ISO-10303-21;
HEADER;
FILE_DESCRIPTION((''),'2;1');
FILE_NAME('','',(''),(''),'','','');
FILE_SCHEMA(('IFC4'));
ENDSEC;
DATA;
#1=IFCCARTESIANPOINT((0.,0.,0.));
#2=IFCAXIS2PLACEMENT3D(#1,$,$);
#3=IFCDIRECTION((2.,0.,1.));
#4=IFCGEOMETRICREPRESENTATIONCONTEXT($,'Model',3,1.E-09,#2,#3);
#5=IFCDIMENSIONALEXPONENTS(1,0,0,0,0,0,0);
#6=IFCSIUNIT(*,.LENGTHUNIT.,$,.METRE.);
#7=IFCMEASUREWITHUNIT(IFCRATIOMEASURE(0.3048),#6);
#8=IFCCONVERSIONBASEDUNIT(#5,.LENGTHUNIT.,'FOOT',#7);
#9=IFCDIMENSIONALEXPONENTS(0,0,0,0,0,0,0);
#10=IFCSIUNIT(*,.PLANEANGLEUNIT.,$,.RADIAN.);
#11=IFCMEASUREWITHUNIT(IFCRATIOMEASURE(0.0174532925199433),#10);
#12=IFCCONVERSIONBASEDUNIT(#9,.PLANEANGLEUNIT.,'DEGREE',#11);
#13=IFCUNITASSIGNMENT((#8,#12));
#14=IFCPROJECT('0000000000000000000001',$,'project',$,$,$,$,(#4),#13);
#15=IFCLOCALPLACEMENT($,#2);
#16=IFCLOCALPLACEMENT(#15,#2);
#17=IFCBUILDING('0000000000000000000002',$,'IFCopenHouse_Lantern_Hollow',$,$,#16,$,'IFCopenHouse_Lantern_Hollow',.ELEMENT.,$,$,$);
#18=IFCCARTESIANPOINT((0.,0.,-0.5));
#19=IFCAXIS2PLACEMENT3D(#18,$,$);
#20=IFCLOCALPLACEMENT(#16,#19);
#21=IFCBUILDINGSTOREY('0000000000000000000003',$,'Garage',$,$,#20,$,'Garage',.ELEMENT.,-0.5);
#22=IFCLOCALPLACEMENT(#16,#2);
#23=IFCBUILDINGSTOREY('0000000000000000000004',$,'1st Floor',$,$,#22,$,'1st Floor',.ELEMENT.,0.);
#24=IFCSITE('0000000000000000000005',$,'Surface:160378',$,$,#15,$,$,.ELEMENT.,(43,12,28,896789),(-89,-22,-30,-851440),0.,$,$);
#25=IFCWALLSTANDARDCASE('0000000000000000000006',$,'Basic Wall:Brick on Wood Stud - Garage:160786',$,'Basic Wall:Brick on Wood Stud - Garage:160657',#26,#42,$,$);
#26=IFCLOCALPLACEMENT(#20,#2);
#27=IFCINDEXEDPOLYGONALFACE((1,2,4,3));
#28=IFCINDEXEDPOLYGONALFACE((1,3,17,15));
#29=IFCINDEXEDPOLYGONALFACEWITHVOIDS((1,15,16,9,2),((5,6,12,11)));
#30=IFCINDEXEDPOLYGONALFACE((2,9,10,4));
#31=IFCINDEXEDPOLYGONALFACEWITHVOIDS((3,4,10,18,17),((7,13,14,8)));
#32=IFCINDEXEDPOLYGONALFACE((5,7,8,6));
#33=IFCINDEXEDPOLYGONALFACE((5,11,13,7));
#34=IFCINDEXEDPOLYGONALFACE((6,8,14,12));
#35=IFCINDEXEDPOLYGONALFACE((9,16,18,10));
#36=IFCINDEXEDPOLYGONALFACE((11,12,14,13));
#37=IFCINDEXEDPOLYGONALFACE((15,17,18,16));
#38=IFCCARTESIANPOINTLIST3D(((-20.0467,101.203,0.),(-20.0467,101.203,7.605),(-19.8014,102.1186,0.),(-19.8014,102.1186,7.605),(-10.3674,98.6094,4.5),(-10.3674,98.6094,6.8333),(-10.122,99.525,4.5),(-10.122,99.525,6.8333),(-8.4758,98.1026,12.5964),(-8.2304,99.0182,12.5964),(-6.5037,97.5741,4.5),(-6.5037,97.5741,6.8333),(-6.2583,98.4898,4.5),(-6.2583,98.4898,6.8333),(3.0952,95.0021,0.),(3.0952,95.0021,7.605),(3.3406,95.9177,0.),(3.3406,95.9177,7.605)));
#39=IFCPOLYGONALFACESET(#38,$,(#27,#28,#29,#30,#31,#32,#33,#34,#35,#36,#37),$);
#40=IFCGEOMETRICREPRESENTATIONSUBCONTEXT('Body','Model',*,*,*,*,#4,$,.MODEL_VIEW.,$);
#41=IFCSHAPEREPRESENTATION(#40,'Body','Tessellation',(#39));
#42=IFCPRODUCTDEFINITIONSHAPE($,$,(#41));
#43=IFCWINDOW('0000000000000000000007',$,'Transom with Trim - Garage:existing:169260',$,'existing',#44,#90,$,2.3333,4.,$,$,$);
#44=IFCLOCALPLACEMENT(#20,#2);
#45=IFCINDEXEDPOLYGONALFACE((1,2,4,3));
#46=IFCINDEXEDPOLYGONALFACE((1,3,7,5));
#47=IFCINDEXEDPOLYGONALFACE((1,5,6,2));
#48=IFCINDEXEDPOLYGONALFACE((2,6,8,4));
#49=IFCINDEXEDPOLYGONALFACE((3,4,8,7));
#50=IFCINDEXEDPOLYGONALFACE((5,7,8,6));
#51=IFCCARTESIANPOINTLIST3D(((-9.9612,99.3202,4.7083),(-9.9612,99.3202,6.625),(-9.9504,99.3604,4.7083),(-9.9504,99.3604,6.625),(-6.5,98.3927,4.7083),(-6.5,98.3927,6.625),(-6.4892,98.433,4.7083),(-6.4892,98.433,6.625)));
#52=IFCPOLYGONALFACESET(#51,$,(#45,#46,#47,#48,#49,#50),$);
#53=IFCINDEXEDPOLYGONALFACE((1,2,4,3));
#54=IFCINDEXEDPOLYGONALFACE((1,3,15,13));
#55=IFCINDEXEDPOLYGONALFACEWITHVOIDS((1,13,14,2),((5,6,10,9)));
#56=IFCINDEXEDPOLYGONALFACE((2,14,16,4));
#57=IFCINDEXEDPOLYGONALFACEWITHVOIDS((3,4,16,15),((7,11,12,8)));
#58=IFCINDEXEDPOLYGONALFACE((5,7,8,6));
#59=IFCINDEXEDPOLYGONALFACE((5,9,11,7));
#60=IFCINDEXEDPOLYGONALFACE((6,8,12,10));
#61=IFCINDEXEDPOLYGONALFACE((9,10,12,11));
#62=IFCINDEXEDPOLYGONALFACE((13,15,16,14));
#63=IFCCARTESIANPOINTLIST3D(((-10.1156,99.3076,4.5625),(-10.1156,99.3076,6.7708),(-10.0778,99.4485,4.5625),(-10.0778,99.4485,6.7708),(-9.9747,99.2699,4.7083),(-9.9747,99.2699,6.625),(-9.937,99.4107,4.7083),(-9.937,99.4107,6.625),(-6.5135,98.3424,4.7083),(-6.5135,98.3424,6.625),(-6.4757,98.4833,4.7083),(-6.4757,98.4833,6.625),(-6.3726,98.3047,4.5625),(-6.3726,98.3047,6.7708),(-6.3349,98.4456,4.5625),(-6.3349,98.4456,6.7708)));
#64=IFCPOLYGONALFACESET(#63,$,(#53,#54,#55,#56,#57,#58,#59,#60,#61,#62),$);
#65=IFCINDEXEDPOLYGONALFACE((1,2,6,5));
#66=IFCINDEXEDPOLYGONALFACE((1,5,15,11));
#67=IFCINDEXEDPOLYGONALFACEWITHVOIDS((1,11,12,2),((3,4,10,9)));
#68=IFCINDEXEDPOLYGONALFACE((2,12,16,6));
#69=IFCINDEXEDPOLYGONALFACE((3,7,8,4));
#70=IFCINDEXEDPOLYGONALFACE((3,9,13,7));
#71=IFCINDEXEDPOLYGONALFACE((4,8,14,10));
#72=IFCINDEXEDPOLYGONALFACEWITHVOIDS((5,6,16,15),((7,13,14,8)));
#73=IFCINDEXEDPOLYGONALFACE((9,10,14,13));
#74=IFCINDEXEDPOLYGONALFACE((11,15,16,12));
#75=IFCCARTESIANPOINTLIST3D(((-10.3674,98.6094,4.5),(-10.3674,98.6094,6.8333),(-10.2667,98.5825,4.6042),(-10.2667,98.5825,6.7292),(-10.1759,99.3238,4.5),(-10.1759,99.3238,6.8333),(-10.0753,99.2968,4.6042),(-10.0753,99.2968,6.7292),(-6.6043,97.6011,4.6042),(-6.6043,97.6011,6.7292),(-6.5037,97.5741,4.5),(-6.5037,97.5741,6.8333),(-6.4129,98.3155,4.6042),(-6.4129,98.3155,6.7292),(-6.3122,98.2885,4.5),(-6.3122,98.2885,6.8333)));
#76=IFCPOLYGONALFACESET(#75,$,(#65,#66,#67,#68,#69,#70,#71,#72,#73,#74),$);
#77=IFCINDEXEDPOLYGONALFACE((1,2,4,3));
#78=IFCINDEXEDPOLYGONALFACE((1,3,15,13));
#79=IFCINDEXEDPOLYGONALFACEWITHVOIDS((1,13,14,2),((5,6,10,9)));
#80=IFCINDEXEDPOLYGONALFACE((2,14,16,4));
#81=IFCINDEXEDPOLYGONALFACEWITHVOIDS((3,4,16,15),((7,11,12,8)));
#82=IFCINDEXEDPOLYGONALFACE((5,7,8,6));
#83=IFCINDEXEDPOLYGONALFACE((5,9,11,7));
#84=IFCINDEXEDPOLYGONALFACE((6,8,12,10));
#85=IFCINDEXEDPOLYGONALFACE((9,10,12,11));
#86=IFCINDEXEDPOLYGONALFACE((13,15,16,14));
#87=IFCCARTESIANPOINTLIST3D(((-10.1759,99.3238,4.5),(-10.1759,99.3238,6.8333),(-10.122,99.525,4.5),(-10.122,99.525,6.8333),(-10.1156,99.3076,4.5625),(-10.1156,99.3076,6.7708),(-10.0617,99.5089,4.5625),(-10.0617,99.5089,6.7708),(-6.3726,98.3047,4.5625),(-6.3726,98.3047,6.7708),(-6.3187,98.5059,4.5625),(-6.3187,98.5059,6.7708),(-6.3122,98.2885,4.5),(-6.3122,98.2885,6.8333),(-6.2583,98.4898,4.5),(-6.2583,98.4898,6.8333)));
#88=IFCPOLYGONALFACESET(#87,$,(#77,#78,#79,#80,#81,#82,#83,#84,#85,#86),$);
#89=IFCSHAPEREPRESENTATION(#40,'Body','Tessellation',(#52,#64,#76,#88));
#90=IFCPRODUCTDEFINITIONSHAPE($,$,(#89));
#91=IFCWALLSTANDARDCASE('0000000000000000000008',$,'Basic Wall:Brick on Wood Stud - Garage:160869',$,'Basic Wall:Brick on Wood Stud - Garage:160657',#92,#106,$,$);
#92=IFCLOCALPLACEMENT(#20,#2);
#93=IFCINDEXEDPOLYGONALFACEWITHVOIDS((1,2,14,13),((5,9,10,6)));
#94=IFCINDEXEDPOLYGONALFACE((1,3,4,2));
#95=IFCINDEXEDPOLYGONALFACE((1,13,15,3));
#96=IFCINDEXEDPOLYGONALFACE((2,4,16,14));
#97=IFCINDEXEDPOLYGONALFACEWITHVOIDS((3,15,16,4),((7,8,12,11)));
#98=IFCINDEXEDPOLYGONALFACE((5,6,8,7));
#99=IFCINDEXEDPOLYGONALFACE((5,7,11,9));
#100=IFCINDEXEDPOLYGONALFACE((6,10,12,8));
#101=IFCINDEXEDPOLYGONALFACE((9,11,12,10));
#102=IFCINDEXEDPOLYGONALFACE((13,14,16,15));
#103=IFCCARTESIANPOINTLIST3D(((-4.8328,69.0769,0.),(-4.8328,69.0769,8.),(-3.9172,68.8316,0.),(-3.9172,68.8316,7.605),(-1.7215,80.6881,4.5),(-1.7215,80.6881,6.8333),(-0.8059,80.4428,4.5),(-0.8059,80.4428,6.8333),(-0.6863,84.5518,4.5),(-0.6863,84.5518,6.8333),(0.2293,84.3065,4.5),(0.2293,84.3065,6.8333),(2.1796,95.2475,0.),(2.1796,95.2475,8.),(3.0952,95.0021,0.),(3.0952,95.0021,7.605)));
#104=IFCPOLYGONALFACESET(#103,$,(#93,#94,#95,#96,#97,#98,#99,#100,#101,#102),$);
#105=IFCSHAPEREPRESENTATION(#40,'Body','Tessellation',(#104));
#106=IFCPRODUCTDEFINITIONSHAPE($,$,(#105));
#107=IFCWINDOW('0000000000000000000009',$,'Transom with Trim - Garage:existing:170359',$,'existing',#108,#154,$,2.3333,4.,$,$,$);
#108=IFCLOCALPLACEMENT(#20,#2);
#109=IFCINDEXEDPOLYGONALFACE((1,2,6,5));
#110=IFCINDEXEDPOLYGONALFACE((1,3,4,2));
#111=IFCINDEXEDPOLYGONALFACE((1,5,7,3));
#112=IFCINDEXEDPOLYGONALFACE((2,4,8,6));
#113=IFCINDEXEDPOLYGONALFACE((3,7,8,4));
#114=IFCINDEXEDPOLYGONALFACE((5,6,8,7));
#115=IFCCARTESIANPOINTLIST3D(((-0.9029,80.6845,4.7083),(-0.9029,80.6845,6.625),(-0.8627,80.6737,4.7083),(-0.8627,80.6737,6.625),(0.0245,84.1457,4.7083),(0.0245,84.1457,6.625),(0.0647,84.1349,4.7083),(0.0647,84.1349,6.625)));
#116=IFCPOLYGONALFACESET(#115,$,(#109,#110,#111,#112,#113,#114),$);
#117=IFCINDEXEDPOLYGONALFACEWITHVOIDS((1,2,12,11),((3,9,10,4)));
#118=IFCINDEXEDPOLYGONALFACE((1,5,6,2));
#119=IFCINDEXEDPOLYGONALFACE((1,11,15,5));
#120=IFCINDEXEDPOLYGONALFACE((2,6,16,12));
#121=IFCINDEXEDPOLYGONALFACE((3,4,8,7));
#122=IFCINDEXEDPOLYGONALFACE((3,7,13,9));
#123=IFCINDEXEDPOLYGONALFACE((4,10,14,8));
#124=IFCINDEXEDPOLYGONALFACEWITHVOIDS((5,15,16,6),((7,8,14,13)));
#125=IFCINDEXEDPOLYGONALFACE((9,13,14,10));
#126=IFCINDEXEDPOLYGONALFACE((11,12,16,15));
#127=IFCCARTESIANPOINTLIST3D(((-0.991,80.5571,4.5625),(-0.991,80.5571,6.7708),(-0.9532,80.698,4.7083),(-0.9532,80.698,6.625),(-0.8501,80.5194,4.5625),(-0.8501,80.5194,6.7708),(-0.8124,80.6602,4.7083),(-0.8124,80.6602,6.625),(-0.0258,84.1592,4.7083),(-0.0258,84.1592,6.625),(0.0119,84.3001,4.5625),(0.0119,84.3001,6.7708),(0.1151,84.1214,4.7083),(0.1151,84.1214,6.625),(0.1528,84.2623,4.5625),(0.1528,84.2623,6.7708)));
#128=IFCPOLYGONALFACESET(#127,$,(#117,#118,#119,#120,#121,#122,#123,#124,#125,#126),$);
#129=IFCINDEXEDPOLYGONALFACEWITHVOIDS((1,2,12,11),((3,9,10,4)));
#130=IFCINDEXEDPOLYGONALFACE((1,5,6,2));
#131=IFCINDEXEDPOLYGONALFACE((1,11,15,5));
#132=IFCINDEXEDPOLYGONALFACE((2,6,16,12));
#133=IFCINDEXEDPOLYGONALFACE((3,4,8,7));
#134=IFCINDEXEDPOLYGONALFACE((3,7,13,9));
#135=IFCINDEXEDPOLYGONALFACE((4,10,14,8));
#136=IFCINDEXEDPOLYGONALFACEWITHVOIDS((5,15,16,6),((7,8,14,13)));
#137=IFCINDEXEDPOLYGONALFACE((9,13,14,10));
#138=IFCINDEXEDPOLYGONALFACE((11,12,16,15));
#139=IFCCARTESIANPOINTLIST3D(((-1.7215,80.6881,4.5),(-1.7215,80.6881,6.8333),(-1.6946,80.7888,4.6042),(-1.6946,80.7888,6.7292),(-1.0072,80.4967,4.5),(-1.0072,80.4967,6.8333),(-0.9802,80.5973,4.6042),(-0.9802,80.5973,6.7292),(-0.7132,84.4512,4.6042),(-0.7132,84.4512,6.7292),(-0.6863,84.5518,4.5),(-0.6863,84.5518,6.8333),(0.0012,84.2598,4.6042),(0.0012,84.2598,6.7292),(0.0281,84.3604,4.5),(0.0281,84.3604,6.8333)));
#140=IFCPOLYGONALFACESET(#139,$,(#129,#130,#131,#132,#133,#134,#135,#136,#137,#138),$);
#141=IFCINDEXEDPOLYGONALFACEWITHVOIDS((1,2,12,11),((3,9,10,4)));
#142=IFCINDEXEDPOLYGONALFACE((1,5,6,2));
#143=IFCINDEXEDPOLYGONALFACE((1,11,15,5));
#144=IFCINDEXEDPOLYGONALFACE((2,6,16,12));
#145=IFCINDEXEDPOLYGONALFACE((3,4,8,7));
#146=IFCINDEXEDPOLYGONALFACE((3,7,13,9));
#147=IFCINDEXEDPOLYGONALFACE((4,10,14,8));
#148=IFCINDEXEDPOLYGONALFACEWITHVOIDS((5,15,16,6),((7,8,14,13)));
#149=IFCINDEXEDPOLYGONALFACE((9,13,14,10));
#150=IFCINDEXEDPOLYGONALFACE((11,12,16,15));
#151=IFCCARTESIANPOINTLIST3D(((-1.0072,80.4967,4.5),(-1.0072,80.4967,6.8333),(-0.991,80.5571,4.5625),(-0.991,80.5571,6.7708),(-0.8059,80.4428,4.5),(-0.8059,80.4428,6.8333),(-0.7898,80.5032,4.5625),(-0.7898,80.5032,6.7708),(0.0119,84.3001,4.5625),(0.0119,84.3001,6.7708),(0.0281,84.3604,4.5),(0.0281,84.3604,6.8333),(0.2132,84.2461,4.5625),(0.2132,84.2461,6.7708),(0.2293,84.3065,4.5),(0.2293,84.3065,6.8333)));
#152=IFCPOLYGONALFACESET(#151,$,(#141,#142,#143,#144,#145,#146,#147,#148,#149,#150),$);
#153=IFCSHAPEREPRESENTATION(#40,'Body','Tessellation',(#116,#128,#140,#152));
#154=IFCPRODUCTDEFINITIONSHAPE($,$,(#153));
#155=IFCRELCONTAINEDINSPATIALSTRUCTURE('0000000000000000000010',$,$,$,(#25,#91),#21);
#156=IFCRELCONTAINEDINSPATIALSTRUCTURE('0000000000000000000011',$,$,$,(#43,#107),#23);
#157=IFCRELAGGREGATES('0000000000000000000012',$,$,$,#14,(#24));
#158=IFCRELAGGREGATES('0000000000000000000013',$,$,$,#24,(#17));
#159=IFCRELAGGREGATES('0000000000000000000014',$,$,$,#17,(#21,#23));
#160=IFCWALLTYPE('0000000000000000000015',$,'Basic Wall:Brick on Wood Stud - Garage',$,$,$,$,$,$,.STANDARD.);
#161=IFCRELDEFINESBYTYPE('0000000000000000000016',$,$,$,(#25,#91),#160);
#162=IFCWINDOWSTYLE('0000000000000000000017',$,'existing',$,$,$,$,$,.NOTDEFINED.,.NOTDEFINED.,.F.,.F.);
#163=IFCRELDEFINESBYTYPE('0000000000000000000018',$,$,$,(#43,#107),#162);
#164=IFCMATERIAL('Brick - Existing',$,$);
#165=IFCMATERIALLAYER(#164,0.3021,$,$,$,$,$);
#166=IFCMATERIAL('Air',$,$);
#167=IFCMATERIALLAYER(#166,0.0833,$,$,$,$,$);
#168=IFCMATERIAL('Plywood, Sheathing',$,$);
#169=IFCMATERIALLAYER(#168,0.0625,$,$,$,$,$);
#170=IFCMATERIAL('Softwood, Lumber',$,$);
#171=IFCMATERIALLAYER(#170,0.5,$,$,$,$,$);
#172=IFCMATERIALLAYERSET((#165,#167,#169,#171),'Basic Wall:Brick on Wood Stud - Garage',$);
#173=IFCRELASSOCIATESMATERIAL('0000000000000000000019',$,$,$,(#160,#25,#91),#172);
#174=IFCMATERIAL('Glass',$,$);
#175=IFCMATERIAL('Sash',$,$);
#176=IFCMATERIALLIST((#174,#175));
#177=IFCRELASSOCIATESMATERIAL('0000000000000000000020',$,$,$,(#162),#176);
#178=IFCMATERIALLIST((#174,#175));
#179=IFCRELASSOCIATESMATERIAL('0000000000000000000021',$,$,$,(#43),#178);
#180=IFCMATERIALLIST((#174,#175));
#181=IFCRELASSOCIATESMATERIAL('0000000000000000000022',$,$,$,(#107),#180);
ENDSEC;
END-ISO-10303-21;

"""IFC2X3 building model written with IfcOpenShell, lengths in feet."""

from ifc_helpers import new_model, entity, si_unit, converted_unit, direction, frame, frame_2d, origin, place, context, subcontext, project, spatial, polyline, rectangle, outline, extrude, clip, bounded_halfspace, source, transform, mapped, material, material_list, layer, layer_set, layer_usage, type_object, type_shapes, element, fill, save


model = new_model("IFC2X3")

# Units and contexts
model_context = context("Model", 3, precision=1e-09, world=origin(), true_north=direction((2.0, 0.0, 1.0)))
body_context = subcontext(model_context, "Body", "Model", "MODEL_VIEW")
ifc_project = project(units=[converted_unit("LENGTHUNIT", "FOOT", entity("IfcRatioMeasure", 0.3048), si_unit("LENGTHUNIT", "METRE"), dimensions=[1, 0, 0, 0, 0, 0, 0]), converted_unit("PLANEANGLEUNIT", "DEGREE", entity("IfcRatioMeasure", 0.0174532925199433), si_unit("PLANEANGLEUNIT", "RADIAN"), dimensions=[0, 0, 0, 0, 0, 0, 0])], contexts=[model_context])

# Site, building, storey
site_placement = place(None, origin())
site = spatial("IfcSite", under=ifc_project, at=site_placement, Name="Surface:160378", CompositionType="ELEMENT", RefLatitude=(43, 12, 28, 896789), RefLongitude=(-89, -22, -30, -851440), RefElevation=0.0)
building_placement = place(site_placement, origin())
building = spatial("IfcBuilding", under=site, at=building_placement, Name="IFCopenHouse_Lantern_Hollow", LongName="IFCopenHouse_Lantern_Hollow", CompositionType="ELEMENT")
storey_1_placement = place(building_placement, frame((0.0, 0.0, -0.5)))
storey_1 = spatial("IfcBuildingStorey", under=building, at=storey_1_placement, Name="Garage", LongName="Garage", CompositionType="ELEMENT", Elevation=-0.5)

# Shared definitions
ifc_material_1 = material(Name="Softwood, Lumber")

# Wall, opening
ifc_material_2 = material(Name="Brick - Existing")
ifc_layer_1 = layer(ifc_material_2, 0.3021)
ifc_material_3 = material(Name="Air")
ifc_layer_2 = layer(ifc_material_3, 0.0833)
ifc_material_4 = material(Name="Plywood, Sheathing")
ifc_layer_3 = layer(ifc_material_4, 0.0625)
ifc_layer_4 = layer(ifc_material_1, 0.5)
ifc_layer_set_1 = layer_set([ifc_layer_1, ifc_layer_2, ifc_layer_3, ifc_layer_4], Name="Basic Wall:Brick on Wood Stud - Garage")
ifc_layer_usage_1 = layer_usage(ifc_layer_set_1, "AXIS2", "NEGATIVE", 0.474)
wall_type_1 = type_object("IfcWallType", Name="Basic Wall:Brick on Wood Stud - Garage", PredefinedType="STANDARD", material=ifc_layer_set_1)
wall_1_placement = place(storey_1_placement, frame((-19.9241, 101.6608, 0.0), z_axis=(0.0, 0.0, 1.0), x_axis=(0.965926, -0.258819, 0.0)))
wall_1 = element("IfcWallStandardCase", 1, at=wall_1_placement, inside=storey_1, type_object=wall_type_1, material=ifc_layer_usage_1, Name="Basic Wall:Brick on Wood Stud - Garage:160786", ObjectType="Basic Wall:Brick on Wood Stud - Garage:160657", context=body_context, shape_type="Clipping", body=[
    clip(clip(extrude(rectangle(XDim=23.9583, YDim=0.9479, at=frame_2d((11.9792, 0.0), x_axis=(-1.0, 0.0))), origin(), (0.0, 0.0, 1.0), 12.5964), bounded_halfspace(frame((11.9792, -0.474, 12.5964), z_axis=(0.384615, 0.0, 0.923077), x_axis=(0.0, 1.0, 0.0)), False, frame((11.9792, -0.474, 12.5964)), polyline([(0.0, 0.0), (11.0313, 0.0), (11.9792, 0.0), (11.9792, 0.9479), (0.0, 0.9479), (0.0, 0.0)]))), bounded_halfspace(frame((0.0, -0.474, 7.605), z_axis=(-0.384615, 0.0, 0.923077), x_axis=(0.0, -1.0, 0.0)), False, frame((0.0, -0.474, 7.605)), polyline([(0.0, 0.0), (0.9479, 0.0), (11.9792, 0.0), (11.9792, 0.9479), (0.0, 0.9479), (0.0, 0.0)]))),
])
opening_1_placement = place(wall_1_placement, frame((10.0208, -0.474, 4.5)))
opening_1 = element("IfcOpeningElement", 2, at=opening_1_placement, cuts=wall_1, ObjectType="Opening", context=body_context, shape_type="SweptSolid", body=[
    extrude(rectangle(XDim=2.3333, YDim=4.0, at=frame_2d((1.1667, 2.0), x_axis=(-1.0, 0.0))), frame((0.0, 0.0, 0.0), z_axis=(0.0, 1.0, 0.0), x_axis=(0.0, 0.0, 1.0)), (0.0, 0.0, 1.0), 0.9479),
])

# Shared definitions
storey_2_placement = place(building_placement, origin())
storey_2 = spatial("IfcBuildingStorey", under=building, at=storey_2_placement, Name="1st Floor", LongName="1st Floor", CompositionType="ELEMENT", Elevation=0.0)

# Window
ifc_material_5 = material(Name="Glass")
ifc_material_6 = material(Name="Sash")
ifc_material_list_1 = material_list([ifc_material_5, ifc_material_6])
ifc_material_list_2 = material_list([ifc_material_5, ifc_material_6])
window_style = type_object("IfcWindowStyle", Name="existing", ConstructionType="NOTDEFINED", OperationType="NOTDEFINED", ParameterTakesPrecedence=False, Sizeable=False, material=ifc_material_list_2)
shared_shape_1 = source(origin(), body_context, "Body", "SweptSolid", [
    extrude(rectangle(XDim=3.5833, YDim=0.0417, at=frame_2d((0.0, 0.0), x_axis=(1.0, 0.0))), frame((2.25, 0.8125, 0.2083)), (0.0, 0.0, 1.0), 1.9167),
    extrude(outline(polyline([(-1.9375, -1.1042), (1.9375, -1.1042), (1.9375, 1.1042), (-1.9375, 1.1042), (-1.9375, -1.1042)]), holes=[polyline([(-1.7917, -0.9583), (-1.7917, 0.9583), (1.7917, 0.9583), (1.7917, -0.9583), (-1.7917, -0.9583)])]), frame((2.25, 0.8854, 1.1667), z_axis=(0.0, -1.0, 0.0), x_axis=(-1.0, 0.0, 0.0)), (0.0, 0.0, 1.0), 0.1458),
    extrude(outline(polyline([(-2.0, -1.1667), (2.0, -1.1667), (2.0, 1.1667), (-2.0, 1.1667), (-2.0, -1.1667)]), holes=[polyline([(-1.8958, -1.0625), (-1.8958, 1.0625), (1.8958, 1.0625), (1.8958, -1.0625), (-1.8958, -1.0625)])]), frame((2.25, 0.7396, 1.1667), z_axis=(0.0, -1.0, 0.0), x_axis=(-1.0, 0.0, 0.0)), (0.0, 0.0, 1.0), 0.7396),
    extrude(outline(polyline([(-1.1667, -2.0), (1.1667, -2.0), (1.1667, 2.0), (-1.1667, 2.0), (-1.1667, -2.0)]), holes=[polyline([(-1.1042, -1.9375), (-1.1042, 1.9375), (1.1042, 1.9375), (1.1042, -1.9375), (-1.1042, -1.9375)])]), frame((2.25, 0.9479, 1.1667), z_axis=(0.0, -1.0, 0.0), x_axis=(0.0, 0.0, -1.0)), (0.0, 0.0, 1.0), 0.2083),
])
type_shapes(window_style, [shared_shape_1])
window_1_placement = place(opening_1_placement, frame((-0.25, 0.0, 0.0)))
window_1 = element("IfcWindow", 3, at=window_1_placement, inside=storey_2, type_object=window_style, material=ifc_material_list_1, Name="Transom with Trim - Garage:existing:169260", ObjectType="existing", OverallHeight=2.3333, OverallWidth=4.0, context=body_context, shape_type="MappedRepresentation", body=[
    mapped(shared_shape_1, transform((0.0, 0.0, 0.0), scale=1.0)),
])
fill(opening_1, window_1)

# Wall, opening, window
ifc_layer_usage_2 = layer_usage(ifc_layer_set_1, "AXIS2", "NEGATIVE", 0.474)
wall_2_placement = place(storey_1_placement, frame((2.6374, 95.1248, 0.0), z_axis=(0.0, 0.0, 1.0), x_axis=(-0.258819, -0.965926, 0.0)))
wall_2 = element("IfcWallStandardCase", 4, at=wall_2_placement, inside=storey_1, type_object=wall_type_1, material=ifc_layer_usage_2, Name="Basic Wall:Brick on Wood Stud - Garage:160869", ObjectType="Basic Wall:Brick on Wood Stud - Garage:160657", context=body_context, shape_type="Clipping", body=[
    clip(extrude(rectangle(XDim=27.0938, YDim=0.9479, at=frame_2d((13.5469, 0.0), x_axis=(-1.0, 0.0))), origin(), (0.0, 0.0, 1.0), 8.0), bounded_halfspace(frame((0.0, -0.474, 8.0), z_axis=(0.0, 0.384615, 0.923077), x_axis=(-1.0, 0.0, 0.0)), False, frame((0.0, -0.474, 8.0)), polyline([(0.0, 0.0), (26.1458, 0.0), (27.0938, 0.0), (27.0938, 0.9479), (0.0, 0.9479), (0.0, 0.0)]))),
])
opening_2_placement = place(wall_2_placement, frame((11.0729, -0.474, 4.5)))
opening_2 = element("IfcOpeningElement", 5, at=opening_2_placement, cuts=wall_2, ObjectType="Opening", context=body_context, shape_type="SweptSolid", body=[
    extrude(rectangle(XDim=2.3333, YDim=4.0, at=frame_2d((1.1667, 2.0), x_axis=(-1.0, 0.0))), frame((0.0, 0.0, 0.0), z_axis=(0.0, 1.0, 0.0), x_axis=(0.0, 0.0, 1.0)), (0.0, 0.0, 1.0), 0.9479),
])
ifc_material_list_3 = material_list([ifc_material_5, ifc_material_6])
window_2_placement = place(opening_2_placement, frame((-0.25, 0.0, 0.0)))
window_2 = element("IfcWindow", 6, at=window_2_placement, inside=storey_2, type_object=window_style, material=ifc_material_list_3, Name="Transom with Trim - Garage:existing:170359", ObjectType="existing", OverallHeight=2.3333, OverallWidth=4.0, context=body_context, shape_type="MappedRepresentation", body=[
    mapped(shared_shape_1, transform((0.0, 0.0, 0.0), scale=1.0)),
])
fill(opening_2, window_2)

save(model, "model.ifc")
